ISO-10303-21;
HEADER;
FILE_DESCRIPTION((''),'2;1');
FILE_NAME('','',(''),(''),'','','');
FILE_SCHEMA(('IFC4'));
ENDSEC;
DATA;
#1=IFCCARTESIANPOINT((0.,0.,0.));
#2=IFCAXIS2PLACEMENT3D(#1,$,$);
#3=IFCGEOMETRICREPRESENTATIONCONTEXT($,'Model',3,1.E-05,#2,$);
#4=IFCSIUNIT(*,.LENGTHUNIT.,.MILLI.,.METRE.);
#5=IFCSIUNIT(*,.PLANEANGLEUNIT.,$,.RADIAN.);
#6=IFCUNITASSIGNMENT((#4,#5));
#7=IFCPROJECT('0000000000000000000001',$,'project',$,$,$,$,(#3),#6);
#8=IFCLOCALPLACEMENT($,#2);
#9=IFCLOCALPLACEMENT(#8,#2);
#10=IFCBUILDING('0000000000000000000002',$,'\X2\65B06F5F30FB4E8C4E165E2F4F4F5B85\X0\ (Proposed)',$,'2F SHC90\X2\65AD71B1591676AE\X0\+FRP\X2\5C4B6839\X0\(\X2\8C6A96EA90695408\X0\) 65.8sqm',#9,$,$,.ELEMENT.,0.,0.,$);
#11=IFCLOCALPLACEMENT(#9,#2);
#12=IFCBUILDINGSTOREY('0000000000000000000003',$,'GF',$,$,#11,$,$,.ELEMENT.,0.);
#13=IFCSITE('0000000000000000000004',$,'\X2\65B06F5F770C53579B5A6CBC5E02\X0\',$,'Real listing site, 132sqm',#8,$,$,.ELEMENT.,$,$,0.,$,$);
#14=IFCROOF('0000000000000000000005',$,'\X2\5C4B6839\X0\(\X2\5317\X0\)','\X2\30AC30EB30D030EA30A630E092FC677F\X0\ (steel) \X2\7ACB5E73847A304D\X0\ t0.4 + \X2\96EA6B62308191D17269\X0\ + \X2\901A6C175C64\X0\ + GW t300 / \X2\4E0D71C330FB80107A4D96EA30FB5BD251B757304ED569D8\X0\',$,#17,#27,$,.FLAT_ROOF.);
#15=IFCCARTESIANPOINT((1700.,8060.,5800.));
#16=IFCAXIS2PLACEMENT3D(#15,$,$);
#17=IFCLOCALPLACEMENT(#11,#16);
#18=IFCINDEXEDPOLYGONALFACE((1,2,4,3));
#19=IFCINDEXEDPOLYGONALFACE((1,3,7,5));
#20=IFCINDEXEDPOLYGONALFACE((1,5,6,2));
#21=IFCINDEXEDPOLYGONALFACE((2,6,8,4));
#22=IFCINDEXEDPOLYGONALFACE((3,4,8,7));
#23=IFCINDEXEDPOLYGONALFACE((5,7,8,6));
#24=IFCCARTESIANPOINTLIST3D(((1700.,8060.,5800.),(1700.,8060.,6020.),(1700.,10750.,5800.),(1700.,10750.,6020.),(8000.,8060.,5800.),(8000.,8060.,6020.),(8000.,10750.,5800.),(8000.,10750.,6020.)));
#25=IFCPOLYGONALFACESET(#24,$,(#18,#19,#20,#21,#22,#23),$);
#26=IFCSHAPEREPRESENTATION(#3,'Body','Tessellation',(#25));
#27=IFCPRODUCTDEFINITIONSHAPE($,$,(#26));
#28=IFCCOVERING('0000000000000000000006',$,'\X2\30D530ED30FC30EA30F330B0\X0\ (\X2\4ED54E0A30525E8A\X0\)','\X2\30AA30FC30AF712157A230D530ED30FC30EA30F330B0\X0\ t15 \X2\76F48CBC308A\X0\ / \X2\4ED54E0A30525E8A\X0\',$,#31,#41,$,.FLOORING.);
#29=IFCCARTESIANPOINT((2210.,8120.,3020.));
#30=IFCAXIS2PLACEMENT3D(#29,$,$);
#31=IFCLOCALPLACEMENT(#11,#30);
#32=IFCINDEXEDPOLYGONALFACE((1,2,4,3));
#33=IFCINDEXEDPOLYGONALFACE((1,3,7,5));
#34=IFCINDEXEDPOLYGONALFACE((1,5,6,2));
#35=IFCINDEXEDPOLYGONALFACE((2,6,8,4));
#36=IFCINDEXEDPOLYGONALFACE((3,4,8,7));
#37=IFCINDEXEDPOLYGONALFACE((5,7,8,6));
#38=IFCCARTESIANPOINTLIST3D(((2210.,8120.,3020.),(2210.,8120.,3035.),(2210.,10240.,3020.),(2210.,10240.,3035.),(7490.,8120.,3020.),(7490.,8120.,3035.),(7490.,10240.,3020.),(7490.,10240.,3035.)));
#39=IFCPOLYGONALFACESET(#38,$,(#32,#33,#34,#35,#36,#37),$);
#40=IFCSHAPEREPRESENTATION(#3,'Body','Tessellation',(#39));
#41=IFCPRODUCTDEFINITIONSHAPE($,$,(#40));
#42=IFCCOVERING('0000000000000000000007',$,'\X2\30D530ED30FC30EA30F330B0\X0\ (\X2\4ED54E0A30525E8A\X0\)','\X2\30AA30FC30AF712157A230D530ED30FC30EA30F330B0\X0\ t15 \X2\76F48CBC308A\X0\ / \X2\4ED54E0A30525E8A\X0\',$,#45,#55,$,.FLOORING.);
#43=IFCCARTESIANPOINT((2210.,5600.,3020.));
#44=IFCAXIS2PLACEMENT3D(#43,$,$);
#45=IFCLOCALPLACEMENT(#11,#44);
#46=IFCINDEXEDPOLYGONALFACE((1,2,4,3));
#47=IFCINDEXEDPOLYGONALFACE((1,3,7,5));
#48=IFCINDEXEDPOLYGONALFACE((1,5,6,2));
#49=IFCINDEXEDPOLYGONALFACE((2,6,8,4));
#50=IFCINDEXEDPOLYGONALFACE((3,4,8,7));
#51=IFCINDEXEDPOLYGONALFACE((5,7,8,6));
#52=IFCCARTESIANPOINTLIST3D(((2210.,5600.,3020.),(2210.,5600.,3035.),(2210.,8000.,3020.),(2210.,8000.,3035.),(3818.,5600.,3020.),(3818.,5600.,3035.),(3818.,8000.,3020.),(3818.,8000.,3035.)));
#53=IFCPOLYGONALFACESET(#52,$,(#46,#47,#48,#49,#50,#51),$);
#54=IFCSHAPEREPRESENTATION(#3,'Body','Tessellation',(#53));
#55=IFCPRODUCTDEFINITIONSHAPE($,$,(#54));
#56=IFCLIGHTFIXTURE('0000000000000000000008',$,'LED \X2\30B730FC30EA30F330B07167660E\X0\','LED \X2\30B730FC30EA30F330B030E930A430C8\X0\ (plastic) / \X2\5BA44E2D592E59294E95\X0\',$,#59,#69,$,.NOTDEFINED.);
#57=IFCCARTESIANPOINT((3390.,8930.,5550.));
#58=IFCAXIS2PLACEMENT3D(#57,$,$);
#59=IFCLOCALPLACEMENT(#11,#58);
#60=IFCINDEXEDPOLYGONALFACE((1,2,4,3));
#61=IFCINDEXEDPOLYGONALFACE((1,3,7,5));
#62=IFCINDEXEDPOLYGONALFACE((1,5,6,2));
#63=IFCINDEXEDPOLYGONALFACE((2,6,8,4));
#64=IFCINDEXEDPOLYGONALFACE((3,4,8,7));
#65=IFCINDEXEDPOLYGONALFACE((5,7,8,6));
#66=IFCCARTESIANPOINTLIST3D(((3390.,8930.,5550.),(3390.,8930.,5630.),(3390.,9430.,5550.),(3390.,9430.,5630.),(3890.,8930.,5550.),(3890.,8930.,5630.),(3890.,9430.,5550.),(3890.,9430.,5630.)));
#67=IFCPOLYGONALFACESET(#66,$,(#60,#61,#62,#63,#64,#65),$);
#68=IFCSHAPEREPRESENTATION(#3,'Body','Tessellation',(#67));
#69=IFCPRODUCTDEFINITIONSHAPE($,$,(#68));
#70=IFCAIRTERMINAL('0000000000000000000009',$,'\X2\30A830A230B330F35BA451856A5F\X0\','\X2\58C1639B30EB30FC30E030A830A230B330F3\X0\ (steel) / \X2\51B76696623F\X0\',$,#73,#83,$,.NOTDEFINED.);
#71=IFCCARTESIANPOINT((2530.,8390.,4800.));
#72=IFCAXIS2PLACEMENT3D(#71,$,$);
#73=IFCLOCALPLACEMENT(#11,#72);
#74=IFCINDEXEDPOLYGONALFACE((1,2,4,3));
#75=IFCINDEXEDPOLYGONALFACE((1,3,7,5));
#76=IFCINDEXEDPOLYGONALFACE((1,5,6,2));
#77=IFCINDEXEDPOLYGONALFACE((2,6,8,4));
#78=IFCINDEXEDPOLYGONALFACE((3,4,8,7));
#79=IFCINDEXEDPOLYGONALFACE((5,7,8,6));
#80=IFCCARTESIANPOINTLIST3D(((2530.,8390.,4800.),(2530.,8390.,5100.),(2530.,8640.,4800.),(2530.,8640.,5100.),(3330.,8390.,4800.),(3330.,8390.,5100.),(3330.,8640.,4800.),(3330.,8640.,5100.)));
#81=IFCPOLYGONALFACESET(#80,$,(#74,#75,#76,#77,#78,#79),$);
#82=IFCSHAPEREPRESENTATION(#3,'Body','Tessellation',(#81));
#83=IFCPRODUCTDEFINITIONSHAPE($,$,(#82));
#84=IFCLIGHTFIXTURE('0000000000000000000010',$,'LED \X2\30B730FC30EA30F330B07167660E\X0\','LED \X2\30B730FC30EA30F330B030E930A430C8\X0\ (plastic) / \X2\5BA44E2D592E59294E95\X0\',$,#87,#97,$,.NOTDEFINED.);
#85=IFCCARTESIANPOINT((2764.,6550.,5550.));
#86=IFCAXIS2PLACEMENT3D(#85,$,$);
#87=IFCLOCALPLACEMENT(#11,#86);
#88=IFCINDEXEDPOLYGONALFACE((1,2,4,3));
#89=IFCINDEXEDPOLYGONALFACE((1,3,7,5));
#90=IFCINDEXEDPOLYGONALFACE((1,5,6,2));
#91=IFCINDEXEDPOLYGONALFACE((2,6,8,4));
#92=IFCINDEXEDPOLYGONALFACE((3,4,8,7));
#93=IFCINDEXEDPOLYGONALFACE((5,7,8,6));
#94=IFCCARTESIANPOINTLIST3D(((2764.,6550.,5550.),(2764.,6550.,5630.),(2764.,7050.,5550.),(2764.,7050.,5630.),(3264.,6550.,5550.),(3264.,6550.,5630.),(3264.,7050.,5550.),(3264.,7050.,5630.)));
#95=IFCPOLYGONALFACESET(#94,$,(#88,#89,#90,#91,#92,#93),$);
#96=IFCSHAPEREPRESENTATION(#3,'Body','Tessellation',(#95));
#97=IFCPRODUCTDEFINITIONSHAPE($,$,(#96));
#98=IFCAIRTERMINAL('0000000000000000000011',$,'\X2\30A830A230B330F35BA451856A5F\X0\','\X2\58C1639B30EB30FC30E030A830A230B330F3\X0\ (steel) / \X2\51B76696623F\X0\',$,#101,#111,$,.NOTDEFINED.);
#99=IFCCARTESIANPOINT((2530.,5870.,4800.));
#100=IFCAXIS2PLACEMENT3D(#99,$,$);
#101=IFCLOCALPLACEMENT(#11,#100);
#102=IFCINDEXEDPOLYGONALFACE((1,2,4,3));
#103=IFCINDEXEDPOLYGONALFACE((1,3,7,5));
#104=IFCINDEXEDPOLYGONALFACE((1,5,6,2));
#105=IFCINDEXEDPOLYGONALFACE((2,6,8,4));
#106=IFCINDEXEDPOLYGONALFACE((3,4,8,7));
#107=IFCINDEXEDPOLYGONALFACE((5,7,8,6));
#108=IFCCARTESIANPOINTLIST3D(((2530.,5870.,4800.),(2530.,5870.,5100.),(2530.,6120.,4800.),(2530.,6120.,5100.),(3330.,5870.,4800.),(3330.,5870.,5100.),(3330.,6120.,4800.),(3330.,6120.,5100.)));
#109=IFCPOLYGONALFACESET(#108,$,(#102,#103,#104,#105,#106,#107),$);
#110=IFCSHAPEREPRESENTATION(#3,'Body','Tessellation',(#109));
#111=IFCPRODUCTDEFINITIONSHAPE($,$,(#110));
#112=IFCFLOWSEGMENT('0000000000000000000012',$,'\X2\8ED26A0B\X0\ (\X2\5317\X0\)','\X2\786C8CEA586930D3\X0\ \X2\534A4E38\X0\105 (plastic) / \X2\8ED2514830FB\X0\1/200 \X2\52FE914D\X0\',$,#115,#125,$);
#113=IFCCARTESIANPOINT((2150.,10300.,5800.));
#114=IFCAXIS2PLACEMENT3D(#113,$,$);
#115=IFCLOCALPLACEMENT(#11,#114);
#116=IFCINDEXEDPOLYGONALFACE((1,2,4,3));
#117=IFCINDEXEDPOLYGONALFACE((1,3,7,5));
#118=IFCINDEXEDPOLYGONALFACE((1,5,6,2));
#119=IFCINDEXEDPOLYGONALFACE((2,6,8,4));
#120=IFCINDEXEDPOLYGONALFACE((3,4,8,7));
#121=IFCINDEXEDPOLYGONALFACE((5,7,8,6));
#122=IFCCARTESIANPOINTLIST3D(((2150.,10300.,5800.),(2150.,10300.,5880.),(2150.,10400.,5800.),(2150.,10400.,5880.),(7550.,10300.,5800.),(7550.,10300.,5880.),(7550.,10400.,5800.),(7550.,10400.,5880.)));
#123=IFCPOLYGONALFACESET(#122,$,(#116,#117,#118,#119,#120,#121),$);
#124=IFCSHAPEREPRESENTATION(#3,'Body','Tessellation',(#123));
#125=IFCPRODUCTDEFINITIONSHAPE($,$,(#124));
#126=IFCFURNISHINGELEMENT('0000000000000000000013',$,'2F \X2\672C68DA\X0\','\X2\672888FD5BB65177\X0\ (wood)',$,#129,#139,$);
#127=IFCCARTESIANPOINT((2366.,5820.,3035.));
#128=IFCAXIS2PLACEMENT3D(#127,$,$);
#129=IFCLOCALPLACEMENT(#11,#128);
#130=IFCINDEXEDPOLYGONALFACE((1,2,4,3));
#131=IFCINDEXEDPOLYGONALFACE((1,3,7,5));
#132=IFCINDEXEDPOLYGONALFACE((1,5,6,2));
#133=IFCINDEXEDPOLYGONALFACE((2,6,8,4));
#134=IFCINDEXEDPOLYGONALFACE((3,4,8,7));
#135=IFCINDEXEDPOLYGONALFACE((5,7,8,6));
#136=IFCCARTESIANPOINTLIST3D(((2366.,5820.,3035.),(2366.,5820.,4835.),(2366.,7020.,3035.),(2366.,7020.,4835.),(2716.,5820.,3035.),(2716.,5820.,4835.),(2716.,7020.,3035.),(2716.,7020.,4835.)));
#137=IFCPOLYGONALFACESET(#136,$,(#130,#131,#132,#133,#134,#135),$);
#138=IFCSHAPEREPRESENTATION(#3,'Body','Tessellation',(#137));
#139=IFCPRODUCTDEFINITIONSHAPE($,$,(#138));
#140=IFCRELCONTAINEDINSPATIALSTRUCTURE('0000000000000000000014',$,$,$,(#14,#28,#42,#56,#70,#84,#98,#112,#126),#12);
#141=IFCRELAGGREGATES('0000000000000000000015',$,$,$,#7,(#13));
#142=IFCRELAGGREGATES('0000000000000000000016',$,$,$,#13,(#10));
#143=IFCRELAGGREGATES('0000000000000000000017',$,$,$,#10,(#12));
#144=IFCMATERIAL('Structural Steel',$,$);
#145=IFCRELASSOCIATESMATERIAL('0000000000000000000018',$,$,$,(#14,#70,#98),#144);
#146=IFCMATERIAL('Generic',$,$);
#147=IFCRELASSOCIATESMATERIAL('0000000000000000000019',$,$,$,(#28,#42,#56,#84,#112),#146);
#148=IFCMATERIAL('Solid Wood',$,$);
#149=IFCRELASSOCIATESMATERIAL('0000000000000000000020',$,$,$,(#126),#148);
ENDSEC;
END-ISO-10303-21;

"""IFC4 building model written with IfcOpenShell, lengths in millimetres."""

from ifc_helpers import new_model, si_unit, frame, frame_2d, origin, place, context, project, spatial, rectangle, extrude, material, element, save


model = new_model("IFC4")

# Units and contexts
model_context = context("Model", 3, precision=1e-05, world=origin())
ifc_project = project(units=[si_unit("LENGTHUNIT", "METRE", prefix="MILLI"), si_unit("PLANEANGLEUNIT", "RADIAN")], contexts=[model_context])

# Site, building, storey
site_placement = place(None, origin())
site = spatial("IfcSite", under=ifc_project, at=site_placement, Name="新潟県南魚沼市", ObjectType="Real listing site, 132sqm", CompositionType="ELEMENT", RefElevation=0.0)
building_placement = place(site_placement, origin())
building = spatial("IfcBuilding", under=site, at=building_placement, Name="新潟・二世帯住宅 (Proposed)", ObjectType="2F SHC90断熱外皮+FRP屋根(豪雪適合) 65.8sqm", CompositionType="ELEMENT", ElevationOfRefHeight=0.0, ElevationOfTerrain=0.0)
storey_placement = place(building_placement, origin())
storey = spatial("IfcBuildingStorey", under=building, at=storey_placement, Name="GF", CompositionType="ELEMENT", Elevation=0.0)

# Shared definitions
ifc_material_1 = material(Name="Solid Wood")

# Roof
ifc_material_2 = material(Name="Structural Steel")
for number, where, name in (
    (1, (1700.0, 8060.0, 5800.0), "屋根(北)"),
):
    element("IfcRoof", number, at=place(storey_placement, frame(where)), inside=storey, material=ifc_material_2, Name=name, Description="ガルバリウム鋼板 (steel) 立平葺き t0.4 + 雪止め金物 + 通気層 + GW t300 / 不燃・耐積雪・寒冷地仕様", PredefinedType="FLAT_ROOF", context=model_context, shape_type="SweptSolid", body=[
        extrude(rectangle(XDim=6300.0, YDim=2690.0, at=frame_2d((3150.0, 1345.0))), frame((1700.0, 8060.0, 5800.0)), (0.0, 0.0, 1.0), 220.0),
    ])

# Coverings
ifc_material_3 = material(Name="Generic")
covering_1_placement = place(storey_placement, frame((2210.0, 8120.0, 3020.0)))
element("IfcCovering", 2, at=covering_1_placement, inside=storey, material=ifc_material_3, Name="フローリング (仕上げ床)", Description="オーク無垢フローリング t15 直貼り / 仕上げ床", PredefinedType="FLOORING", context=model_context, shape_type="SweptSolid", body=[
    extrude(rectangle(XDim=5280.0, YDim=2120.0, at=frame_2d((2640.0, 1060.0))), frame((2210.0, 8120.0, 3020.0)), (0.0, 0.0, 1.0), 15.0),
])
covering_2_placement = place(storey_placement, frame((2210.0, 5600.0, 3020.0)))
element("IfcCovering", 3, at=covering_2_placement, inside=storey, material=ifc_material_3, Name="フローリング (仕上げ床)", Description="オーク無垢フローリング t15 直貼り / 仕上げ床", PredefinedType="FLOORING", context=model_context, shape_type="SweptSolid", body=[
    extrude(rectangle(XDim=1608.0, YDim=2400.0, at=frame_2d((804.0, 1200.0))), frame((2210.0, 5600.0, 3020.0)), (0.0, 0.0, 1.0), 15.0),
])

# Light fixture
light_fixture_1_placement = place(storey_placement, frame((3390.0, 8930.0, 5550.0)))
element("IfcLightFixture", 4, at=light_fixture_1_placement, inside=storey, material=ifc_material_3, Name="LED シーリング照明", Description="LED シーリングライト (plastic) / 室中央天井", PredefinedType="NOTDEFINED", context=model_context, shape_type="SweptSolid", body=[
    extrude(rectangle(XDim=500.0, YDim=500.0, at=frame_2d((250.0, 250.0))), frame((3390.0, 8930.0, 5550.0)), (0.0, 0.0, 1.0), 80.0),
])

# Air terminal
air_terminal_1_placement = place(storey_placement, frame((2530.0, 8390.0, 4800.0)))
element("IfcAirTerminal", 5, at=air_terminal_1_placement, inside=storey, material=ifc_material_2, Name="エアコン室内機", Description="壁掛ルームエアコン (steel) / 冷暖房", PredefinedType="NOTDEFINED", context=model_context, shape_type="SweptSolid", body=[
    extrude(rectangle(XDim=800.0, YDim=250.0, at=frame_2d((400.0, 125.0))), frame((2530.0, 8390.0, 4800.0)), (0.0, 0.0, 1.0), 300.0),
])

# Light fixture
light_fixture_2_placement = place(storey_placement, frame((2764.0, 6550.0, 5550.0)))
element("IfcLightFixture", 6, at=light_fixture_2_placement, inside=storey, material=ifc_material_3, Name="LED シーリング照明", Description="LED シーリングライト (plastic) / 室中央天井", PredefinedType="NOTDEFINED", context=model_context, shape_type="SweptSolid", body=[
    extrude(rectangle(XDim=500.0, YDim=500.0, at=frame_2d((250.0, 250.0))), frame((2764.0, 6550.0, 5550.0)), (0.0, 0.0, 1.0), 80.0),
])

# Air terminal
air_terminal_2_placement = place(storey_placement, frame((2530.0, 5870.0, 4800.0)))
element("IfcAirTerminal", 7, at=air_terminal_2_placement, inside=storey, material=ifc_material_2, Name="エアコン室内機", Description="壁掛ルームエアコン (steel) / 冷暖房", PredefinedType="NOTDEFINED", context=model_context, shape_type="SweptSolid", body=[
    extrude(rectangle(XDim=800.0, YDim=250.0, at=frame_2d((400.0, 125.0))), frame((2530.0, 5870.0, 4800.0)), (0.0, 0.0, 1.0), 300.0),
])

# Flow segment
flow_segment_placement = place(storey_placement, frame((2150.0, 10300.0, 5800.0)))
element("IfcFlowSegment", 8, at=flow_segment_placement, inside=storey, material=ifc_material_3, Name="軒樋 (北)", Description="硬質塩ビ 半丸105 (plastic) / 軒先・1/200 勾配", context=model_context, shape_type="SweptSolid", body=[
    extrude(rectangle(XDim=5400.0, YDim=100.0, at=frame_2d((2700.0, 50.0))), frame((2150.0, 10300.0, 5800.0)), (0.0, 0.0, 1.0), 80.0),
])

# Furnishing element
furnishing_placement = place(storey_placement, frame((2366.0, 5820.0, 3035.0)))
element("IfcFurnishingElement", 9, at=furnishing_placement, inside=storey, material=ifc_material_1, Name="2F 本棚", Description="木製家具 (wood)", context=model_context, shape_type="SweptSolid", body=[
    extrude(rectangle(XDim=350.0, YDim=1200.0, at=frame_2d((175.0, 600.0))), frame((2366.0, 5820.0, 3035.0)), (0.0, 0.0, 1.0), 1800.0),
])

save(model, "model.ifc")
